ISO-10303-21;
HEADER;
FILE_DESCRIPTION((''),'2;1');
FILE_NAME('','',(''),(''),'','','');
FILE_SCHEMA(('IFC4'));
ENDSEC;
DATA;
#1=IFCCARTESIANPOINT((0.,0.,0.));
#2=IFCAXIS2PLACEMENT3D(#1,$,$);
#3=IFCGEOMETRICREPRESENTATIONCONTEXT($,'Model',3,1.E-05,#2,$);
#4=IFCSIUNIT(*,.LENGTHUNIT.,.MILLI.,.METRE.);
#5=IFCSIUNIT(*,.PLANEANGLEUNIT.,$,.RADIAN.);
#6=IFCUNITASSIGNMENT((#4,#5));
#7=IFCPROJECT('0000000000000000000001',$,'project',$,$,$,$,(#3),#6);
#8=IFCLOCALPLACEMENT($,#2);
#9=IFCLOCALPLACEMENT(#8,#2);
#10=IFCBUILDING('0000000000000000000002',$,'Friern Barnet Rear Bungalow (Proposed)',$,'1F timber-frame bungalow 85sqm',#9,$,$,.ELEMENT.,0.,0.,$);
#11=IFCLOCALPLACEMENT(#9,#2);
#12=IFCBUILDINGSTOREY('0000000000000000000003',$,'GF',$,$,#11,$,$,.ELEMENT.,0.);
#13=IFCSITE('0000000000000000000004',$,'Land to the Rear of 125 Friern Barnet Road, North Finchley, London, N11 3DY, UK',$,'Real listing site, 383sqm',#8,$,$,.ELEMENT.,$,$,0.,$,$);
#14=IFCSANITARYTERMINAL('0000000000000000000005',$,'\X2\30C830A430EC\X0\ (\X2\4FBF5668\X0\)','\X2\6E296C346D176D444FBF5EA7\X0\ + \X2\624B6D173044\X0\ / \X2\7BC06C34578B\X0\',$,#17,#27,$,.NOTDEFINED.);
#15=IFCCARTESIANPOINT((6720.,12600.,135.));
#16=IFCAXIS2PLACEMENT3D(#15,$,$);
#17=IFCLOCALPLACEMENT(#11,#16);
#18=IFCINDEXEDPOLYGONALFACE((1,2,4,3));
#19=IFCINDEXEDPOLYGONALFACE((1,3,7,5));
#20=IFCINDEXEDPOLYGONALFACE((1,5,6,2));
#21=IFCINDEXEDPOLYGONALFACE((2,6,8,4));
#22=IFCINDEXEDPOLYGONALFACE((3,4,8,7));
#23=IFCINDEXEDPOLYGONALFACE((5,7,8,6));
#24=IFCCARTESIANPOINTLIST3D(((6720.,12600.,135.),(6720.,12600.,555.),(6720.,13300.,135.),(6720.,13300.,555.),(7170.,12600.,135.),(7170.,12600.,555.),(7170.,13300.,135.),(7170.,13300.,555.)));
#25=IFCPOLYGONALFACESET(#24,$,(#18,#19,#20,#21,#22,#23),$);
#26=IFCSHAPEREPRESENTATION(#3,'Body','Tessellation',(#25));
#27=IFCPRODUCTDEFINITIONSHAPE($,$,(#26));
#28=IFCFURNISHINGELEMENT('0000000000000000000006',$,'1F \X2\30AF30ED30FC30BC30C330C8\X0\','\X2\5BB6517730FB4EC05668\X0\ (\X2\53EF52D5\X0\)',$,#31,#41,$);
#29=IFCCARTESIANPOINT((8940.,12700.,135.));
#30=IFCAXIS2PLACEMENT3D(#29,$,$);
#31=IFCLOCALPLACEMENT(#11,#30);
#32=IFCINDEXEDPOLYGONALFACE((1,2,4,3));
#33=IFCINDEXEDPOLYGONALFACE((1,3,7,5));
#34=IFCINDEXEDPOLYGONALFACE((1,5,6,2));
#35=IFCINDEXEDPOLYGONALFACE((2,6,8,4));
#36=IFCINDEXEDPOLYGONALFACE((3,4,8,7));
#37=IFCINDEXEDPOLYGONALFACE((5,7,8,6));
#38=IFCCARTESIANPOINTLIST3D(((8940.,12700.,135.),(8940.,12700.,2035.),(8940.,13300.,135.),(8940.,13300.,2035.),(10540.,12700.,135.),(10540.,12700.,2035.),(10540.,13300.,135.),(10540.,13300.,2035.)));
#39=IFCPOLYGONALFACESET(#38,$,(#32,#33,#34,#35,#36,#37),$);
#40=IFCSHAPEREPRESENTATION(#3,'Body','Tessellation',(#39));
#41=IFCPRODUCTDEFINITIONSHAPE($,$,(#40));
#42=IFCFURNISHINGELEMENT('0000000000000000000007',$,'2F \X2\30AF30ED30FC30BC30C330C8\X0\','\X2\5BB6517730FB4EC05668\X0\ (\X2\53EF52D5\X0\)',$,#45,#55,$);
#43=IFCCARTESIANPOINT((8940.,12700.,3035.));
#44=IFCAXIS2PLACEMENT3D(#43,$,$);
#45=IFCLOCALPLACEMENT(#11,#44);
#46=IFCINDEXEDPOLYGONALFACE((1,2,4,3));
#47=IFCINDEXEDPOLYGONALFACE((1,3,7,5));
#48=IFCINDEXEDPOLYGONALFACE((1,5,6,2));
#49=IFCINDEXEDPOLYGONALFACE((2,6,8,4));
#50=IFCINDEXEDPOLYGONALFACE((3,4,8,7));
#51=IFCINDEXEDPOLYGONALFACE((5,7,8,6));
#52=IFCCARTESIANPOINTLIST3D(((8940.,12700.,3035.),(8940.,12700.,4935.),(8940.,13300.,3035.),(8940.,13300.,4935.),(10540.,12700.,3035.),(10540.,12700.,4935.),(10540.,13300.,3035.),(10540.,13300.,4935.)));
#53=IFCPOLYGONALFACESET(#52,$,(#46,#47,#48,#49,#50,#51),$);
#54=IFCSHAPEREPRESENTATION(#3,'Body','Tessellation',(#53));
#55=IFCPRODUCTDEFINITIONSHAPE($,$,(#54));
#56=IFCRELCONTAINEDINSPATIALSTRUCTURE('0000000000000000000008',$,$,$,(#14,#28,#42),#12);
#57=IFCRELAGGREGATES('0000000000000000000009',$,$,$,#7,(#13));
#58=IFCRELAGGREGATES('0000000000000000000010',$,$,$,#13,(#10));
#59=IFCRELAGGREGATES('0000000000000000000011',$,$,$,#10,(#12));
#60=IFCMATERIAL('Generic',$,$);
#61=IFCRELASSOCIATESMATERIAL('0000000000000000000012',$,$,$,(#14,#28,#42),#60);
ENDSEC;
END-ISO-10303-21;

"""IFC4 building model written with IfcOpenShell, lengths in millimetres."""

from ifc_helpers import new_model, si_unit, frame, frame_2d, origin, place, context, project, spatial, rectangle, extrude, material, element, save


model = new_model("IFC4")

# Units and contexts
model_context = context("Model", 3, precision=1e-05, world=origin())
ifc_project = project(units=[si_unit("LENGTHUNIT", "METRE", prefix="MILLI"), si_unit("PLANEANGLEUNIT", "RADIAN")], contexts=[model_context])

# Site, building, storey
site_placement = place(None, origin())
site = spatial("IfcSite", under=ifc_project, at=site_placement, Name="Land to the Rear of 125 Friern Barnet Road, North Finchley, London, N11 3DY, UK", ObjectType="Real listing site, 383sqm", CompositionType="ELEMENT", RefElevation=0.0)
building_placement = place(site_placement, origin())
building = spatial("IfcBuilding", under=site, at=building_placement, Name="Friern Barnet Rear Bungalow (Proposed)", ObjectType="1F timber-frame bungalow 85sqm", CompositionType="ELEMENT", ElevationOfRefHeight=0.0, ElevationOfTerrain=0.0)
storey_placement = place(building_placement, origin())
storey = spatial("IfcBuildingStorey", under=building, at=storey_placement, Name="GF", CompositionType="ELEMENT", Elevation=0.0)

# Sanitary terminal
ifc_material_1 = material(Name="Generic")
sanitary_terminal_1_placement = place(storey_placement, frame((6720.0, 12600.0, 135.0)))
element("IfcSanitaryTerminal", 1, at=sanitary_terminal_1_placement, inside=storey, material=ifc_material_1, Name="トイレ (便器)", Description="温水洗浄便座 + 手洗い / 節水型", PredefinedType="NOTDEFINED", context=model_context, shape_type="SweptSolid", body=[
    extrude(rectangle(XDim=450.0, YDim=700.0, at=frame_2d((225.0, 350.0))), frame((6720.0, 12600.0, 135.0)), (0.0, 0.0, 1.0), 420.0),
])

# Furnishing elements
furnishing_1_placement = place(storey_placement, frame((8940.0, 12700.0, 135.0)))
element("IfcFurnishingElement", 2, at=furnishing_1_placement, inside=storey, material=ifc_material_1, Name="1F クローゼット", Description="家具・什器 (可動)", context=model_context, shape_type="SweptSolid", body=[
    extrude(rectangle(XDim=1600.0, YDim=600.0, at=frame_2d((800.0, 300.0))), frame((8940.0, 12700.0, 135.0)), (0.0, 0.0, 1.0), 1900.0),
])
furnishing_2_placement = place(storey_placement, frame((8940.0, 12700.0, 3035.0)))
element("IfcFurnishingElement", 3, at=furnishing_2_placement, inside=storey, material=ifc_material_1, Name="2F クローゼット", Description="家具・什器 (可動)", context=model_context, shape_type="SweptSolid", body=[
    extrude(rectangle(XDim=1600.0, YDim=600.0, at=frame_2d((800.0, 300.0))), frame((8940.0, 12700.0, 3035.0)), (0.0, 0.0, 1.0), 1900.0),
])

save(model, "model.ifc")
